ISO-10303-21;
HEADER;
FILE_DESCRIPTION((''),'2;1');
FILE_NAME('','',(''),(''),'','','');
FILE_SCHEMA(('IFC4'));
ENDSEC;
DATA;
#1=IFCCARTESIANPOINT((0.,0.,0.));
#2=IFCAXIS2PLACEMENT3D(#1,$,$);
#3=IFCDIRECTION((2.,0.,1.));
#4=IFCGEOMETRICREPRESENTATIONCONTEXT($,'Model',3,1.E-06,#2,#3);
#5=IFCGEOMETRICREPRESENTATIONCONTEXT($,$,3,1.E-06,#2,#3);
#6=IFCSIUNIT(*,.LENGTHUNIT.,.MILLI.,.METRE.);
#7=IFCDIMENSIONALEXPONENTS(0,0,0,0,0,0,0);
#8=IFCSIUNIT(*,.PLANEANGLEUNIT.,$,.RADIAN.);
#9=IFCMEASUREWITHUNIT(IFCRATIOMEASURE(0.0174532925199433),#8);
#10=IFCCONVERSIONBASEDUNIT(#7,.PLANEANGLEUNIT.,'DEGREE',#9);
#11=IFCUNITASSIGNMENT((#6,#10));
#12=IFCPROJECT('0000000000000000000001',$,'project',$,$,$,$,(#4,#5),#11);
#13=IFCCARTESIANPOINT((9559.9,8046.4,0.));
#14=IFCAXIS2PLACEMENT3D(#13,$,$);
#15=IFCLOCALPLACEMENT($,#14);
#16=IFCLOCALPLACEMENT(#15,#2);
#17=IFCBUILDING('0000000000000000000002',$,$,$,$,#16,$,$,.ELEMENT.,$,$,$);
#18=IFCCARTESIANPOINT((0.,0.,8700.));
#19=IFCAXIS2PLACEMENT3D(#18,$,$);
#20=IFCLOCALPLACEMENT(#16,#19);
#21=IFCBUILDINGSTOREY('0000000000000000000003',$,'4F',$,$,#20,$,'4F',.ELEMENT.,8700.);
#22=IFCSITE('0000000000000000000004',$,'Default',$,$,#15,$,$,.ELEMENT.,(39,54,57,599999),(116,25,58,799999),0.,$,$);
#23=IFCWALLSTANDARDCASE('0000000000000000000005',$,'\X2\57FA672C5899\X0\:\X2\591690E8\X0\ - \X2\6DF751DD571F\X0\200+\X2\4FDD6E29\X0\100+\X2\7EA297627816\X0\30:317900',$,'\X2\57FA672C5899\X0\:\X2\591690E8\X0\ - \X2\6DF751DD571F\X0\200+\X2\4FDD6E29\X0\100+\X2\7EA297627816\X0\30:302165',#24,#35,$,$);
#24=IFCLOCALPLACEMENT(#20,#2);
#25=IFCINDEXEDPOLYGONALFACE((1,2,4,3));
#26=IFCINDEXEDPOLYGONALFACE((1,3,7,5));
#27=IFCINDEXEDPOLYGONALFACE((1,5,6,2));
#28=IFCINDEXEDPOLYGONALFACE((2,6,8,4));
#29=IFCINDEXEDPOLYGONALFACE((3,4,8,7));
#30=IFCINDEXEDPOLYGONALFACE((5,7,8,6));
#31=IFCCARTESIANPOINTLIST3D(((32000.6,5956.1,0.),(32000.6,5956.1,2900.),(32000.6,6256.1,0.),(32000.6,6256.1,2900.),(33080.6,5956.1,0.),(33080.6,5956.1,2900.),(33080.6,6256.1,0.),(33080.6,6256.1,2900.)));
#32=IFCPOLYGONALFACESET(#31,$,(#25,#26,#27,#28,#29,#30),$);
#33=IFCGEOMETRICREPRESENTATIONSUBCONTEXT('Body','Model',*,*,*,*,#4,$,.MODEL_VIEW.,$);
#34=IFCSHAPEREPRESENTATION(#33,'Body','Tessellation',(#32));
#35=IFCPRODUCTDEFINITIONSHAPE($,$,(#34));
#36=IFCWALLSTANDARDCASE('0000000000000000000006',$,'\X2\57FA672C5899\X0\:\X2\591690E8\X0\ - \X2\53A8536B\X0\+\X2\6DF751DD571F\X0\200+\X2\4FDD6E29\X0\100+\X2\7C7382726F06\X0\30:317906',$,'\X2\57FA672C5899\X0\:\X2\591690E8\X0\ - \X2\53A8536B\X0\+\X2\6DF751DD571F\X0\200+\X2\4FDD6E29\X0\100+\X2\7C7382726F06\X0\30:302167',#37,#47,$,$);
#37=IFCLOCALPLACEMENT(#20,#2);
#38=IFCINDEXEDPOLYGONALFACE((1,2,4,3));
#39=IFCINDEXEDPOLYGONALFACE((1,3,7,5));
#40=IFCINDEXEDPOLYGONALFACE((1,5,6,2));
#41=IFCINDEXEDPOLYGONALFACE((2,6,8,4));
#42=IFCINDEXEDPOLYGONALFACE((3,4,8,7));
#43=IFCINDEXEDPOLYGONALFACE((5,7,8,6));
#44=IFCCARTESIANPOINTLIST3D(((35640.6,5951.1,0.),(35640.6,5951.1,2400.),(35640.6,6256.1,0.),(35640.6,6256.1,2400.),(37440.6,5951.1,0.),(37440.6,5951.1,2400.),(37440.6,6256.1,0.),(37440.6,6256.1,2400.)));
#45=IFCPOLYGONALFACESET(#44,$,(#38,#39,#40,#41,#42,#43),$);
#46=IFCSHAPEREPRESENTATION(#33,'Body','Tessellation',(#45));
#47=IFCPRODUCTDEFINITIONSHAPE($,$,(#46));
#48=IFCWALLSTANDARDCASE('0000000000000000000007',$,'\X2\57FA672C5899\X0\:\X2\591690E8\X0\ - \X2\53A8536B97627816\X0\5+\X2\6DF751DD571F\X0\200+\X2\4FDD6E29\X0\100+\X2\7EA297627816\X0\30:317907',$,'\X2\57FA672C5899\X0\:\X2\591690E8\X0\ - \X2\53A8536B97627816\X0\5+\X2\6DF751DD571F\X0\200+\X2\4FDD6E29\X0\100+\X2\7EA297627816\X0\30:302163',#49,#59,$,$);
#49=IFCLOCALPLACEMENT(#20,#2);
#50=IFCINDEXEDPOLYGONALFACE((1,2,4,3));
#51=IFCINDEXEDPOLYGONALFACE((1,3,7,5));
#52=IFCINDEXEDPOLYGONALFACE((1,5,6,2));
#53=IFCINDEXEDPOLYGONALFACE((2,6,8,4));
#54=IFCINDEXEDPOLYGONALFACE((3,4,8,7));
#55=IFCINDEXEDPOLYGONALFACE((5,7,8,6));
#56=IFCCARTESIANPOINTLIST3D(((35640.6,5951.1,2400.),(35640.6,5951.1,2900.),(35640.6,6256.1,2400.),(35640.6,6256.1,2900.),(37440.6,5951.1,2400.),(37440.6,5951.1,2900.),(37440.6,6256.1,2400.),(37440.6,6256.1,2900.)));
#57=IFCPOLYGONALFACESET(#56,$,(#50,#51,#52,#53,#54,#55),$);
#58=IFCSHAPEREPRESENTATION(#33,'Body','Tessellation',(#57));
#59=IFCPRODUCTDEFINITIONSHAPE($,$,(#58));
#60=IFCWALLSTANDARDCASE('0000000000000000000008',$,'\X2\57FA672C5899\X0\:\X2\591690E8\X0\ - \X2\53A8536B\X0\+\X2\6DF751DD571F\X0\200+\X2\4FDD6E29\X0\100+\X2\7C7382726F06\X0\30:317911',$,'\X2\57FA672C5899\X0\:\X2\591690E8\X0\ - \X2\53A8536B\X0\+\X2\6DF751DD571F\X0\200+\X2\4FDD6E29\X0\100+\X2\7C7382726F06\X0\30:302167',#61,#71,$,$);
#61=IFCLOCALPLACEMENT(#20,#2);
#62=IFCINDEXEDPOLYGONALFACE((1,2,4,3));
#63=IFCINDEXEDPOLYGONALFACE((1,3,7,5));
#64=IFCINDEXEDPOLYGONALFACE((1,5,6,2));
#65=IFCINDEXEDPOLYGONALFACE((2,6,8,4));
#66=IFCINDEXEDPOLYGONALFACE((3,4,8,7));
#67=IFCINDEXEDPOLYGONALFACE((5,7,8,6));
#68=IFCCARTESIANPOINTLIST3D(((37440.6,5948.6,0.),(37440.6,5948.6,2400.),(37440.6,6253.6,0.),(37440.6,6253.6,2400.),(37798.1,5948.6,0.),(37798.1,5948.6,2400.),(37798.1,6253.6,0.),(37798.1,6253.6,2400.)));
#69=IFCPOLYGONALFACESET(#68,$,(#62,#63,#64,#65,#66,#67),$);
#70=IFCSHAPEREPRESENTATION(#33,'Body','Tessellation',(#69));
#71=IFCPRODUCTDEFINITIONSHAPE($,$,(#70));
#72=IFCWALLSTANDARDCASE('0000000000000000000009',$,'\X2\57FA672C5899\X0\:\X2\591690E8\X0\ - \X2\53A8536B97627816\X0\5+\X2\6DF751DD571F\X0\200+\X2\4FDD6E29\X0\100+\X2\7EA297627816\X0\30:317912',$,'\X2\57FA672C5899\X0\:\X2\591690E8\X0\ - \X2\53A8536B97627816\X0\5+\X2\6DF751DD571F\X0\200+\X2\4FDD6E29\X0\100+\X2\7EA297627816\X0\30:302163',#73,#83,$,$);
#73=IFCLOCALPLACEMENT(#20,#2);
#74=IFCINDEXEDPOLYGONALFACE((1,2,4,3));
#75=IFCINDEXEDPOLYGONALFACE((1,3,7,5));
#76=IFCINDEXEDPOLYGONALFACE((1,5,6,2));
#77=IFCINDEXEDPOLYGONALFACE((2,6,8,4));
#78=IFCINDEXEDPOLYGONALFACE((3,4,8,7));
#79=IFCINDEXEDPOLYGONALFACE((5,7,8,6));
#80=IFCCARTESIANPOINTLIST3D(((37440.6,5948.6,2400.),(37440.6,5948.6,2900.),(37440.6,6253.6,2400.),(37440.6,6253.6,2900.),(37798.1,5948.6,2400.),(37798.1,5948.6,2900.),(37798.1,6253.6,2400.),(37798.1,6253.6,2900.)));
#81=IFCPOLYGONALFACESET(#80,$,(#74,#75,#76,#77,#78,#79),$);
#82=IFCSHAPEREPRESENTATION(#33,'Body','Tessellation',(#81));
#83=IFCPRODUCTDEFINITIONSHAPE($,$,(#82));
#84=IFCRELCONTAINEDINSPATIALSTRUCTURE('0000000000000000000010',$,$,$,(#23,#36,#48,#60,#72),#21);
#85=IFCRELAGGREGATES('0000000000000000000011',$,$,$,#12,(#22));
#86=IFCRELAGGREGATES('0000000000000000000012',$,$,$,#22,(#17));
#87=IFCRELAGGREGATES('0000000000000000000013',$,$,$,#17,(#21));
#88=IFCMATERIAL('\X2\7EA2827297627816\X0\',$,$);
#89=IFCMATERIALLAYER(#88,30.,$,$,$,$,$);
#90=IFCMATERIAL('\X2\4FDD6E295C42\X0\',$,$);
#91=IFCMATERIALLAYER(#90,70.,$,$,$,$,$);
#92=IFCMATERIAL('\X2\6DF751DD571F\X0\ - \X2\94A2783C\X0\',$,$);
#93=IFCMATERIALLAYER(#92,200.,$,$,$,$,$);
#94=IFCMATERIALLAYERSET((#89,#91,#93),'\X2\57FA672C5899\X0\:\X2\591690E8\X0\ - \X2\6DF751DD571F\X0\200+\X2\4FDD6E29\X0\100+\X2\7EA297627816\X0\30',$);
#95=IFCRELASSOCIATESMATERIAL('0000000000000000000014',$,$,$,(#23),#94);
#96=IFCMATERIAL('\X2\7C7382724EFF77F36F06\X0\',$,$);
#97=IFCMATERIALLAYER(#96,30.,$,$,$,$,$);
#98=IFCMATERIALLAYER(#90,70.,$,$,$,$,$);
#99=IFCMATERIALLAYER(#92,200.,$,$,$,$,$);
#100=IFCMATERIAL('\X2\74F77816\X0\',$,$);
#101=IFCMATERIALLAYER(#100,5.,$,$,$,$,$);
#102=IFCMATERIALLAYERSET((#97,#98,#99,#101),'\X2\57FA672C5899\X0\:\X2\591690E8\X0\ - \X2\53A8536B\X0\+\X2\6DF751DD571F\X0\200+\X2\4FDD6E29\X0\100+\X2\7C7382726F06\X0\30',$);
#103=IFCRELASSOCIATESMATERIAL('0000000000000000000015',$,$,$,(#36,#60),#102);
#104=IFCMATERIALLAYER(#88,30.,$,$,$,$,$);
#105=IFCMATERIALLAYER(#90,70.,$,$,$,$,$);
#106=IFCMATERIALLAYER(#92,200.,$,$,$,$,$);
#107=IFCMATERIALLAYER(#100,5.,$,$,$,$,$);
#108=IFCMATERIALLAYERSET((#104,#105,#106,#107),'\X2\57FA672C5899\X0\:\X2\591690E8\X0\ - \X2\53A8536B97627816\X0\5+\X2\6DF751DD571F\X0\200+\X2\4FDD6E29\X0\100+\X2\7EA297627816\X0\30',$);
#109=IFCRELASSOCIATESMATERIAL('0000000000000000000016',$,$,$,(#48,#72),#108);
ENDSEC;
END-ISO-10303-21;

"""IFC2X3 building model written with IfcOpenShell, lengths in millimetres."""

from ifc_helpers import new_model, entity, si_unit, converted_unit, direction, frame, frame_2d, origin, place, context, subcontext, project, spatial, rectangle, extrude, material, layer, layer_set, layer_usage, element, save


model = new_model("IFC2X3")

# Units and contexts
model_context = context("Model", 3, precision=1e-06, world=origin(), true_north=direction((2.0, 0.0, 1.0)))
context_of_model = context(None, 3, precision=1e-06, world=origin(), true_north=direction((2.0, 0.0, 1.0)))
body_context = subcontext(model_context, "Body", "Model", "MODEL_VIEW")
ifc_project = project(units=[si_unit("LENGTHUNIT", "METRE", prefix="MILLI"), converted_unit("PLANEANGLEUNIT", "DEGREE", entity("IfcRatioMeasure", 0.0174532925199433), si_unit("PLANEANGLEUNIT", "RADIAN"), dimensions=[0, 0, 0, 0, 0, 0, 0])], contexts=[model_context, context_of_model])

# Site, building, storey
site_placement = place(None, frame((9559.9, 8046.4, 0.0)))
site = spatial("IfcSite", under=ifc_project, at=site_placement, Name="Default", CompositionType="ELEMENT", RefLatitude=(39, 54, 57, 599999), RefLongitude=(116, 25, 58, 799999), RefElevation=0.0)
building_placement = place(site_placement, origin())
building = spatial("IfcBuilding", under=site, at=building_placement, CompositionType="ELEMENT")
storey_placement = place(building_placement, frame((0.0, 0.0, 8700.0)))
storey = spatial("IfcBuildingStorey", under=building, at=storey_placement, Name="4F", LongName="4F", CompositionType="ELEMENT", Elevation=8700.0)

# Shared definitions
ifc_material_1 = material(Name="混凝土 - 钢砼")
ifc_material_2 = material(Name="瓷砖")

# Shared definitions
ifc_material_3 = material(Name="红色面砖")
ifc_layer_1 = layer(ifc_material_3, 30.0)
ifc_material_4 = material(Name="保温层")
ifc_layer_2 = layer(ifc_material_4, 70.0)
ifc_layer_3 = layer(ifc_material_1, 200.0)
ifc_layer_set_1 = layer_set([ifc_layer_1, ifc_layer_2, ifc_layer_3], Name="基本墙:外部 - 混凝土200+保温100+红面砖30")

# Shared definitions
ifc_layer_4 = layer(ifc_material_3, 30.0)
ifc_layer_5 = layer(ifc_material_4, 70.0)
ifc_layer_6 = layer(ifc_material_1, 200.0)
ifc_layer_7 = layer(ifc_material_2, 5.0)
ifc_layer_set_2 = layer_set([ifc_layer_4, ifc_layer_5, ifc_layer_6, ifc_layer_7], Name="基本墙:外部 - 厨卫面砖5+混凝土200+保温100+红面砖30")

# Walls
ifc_layer_usage_1 = layer_usage(ifc_layer_set_1, "AXIS2", "POSITIVE", -150.0)
wall_1_placement = place(storey_placement, frame((33080.6, 6106.1, 0.0), z_axis=(0.0, 0.0, 1.0), x_axis=(-1.0, 0.0, 0.0)))
element("IfcWallStandardCase", 1, at=wall_1_placement, inside=storey, material=ifc_layer_usage_1, Name="基本墙:外部 - 混凝土200+保温100+红面砖30:317900", ObjectType="基本墙:外部 - 混凝土200+保温100+红面砖30:302165", context=body_context, shape_type="SweptSolid", body=[
    extrude(rectangle(XDim=1080.0, YDim=300.0, at=frame_2d((540.0, 0.0), x_axis=(-1.0, 0.0))), origin(), (0.0, 0.0, 1.0), 2900.0),
])
ifc_material_5 = material(Name="米色仿石漆")
ifc_layer_8 = layer(ifc_material_5, 30.0)
ifc_layer_9 = layer(ifc_material_4, 70.0)
ifc_layer_10 = layer(ifc_material_1, 200.0)
ifc_layer_11 = layer(ifc_material_2, 5.0)
ifc_layer_set_3 = layer_set([ifc_layer_8, ifc_layer_9, ifc_layer_10, ifc_layer_11], Name="基本墙:外部 - 厨卫+混凝土200+保温100+米色漆30")
ifc_layer_usage_2 = layer_usage(ifc_layer_set_3, "AXIS2", "POSITIVE", -152.5)
wall_2_placement = place(storey_placement, frame((37440.6, 6103.6, 0.0), z_axis=(0.0, 0.0, 1.0), x_axis=(-1.0, 0.0, 0.0)))
element("IfcWallStandardCase", 2, at=wall_2_placement, inside=storey, material=ifc_layer_usage_2, Name="基本墙:外部 - 厨卫+混凝土200+保温100+米色漆30:317906", ObjectType="基本墙:外部 - 厨卫+混凝土200+保温100+米色漆30:302167", context=body_context, shape_type="SweptSolid", body=[
    extrude(rectangle(XDim=1800.0, YDim=305.0, at=frame_2d((900.0, 0.0), x_axis=(-1.0, 0.0))), origin(), (0.0, 0.0, 1.0), 2400.0),
])
ifc_layer_usage_3 = layer_usage(ifc_layer_set_2, "AXIS2", "POSITIVE", -152.5)
wall_3_placement = place(storey_placement, frame((37440.6, 6103.6, 2400.0), z_axis=(0.0, 0.0, 1.0), x_axis=(-1.0, 0.0, 0.0)))
element("IfcWallStandardCase", 3, at=wall_3_placement, inside=storey, material=ifc_layer_usage_3, Name="基本墙:外部 - 厨卫面砖5+混凝土200+保温100+红面砖30:317907", ObjectType="基本墙:外部 - 厨卫面砖5+混凝土200+保温100+红面砖30:302163", context=body_context, shape_type="SweptSolid", body=[
    extrude(rectangle(XDim=1800.0, YDim=305.0, at=frame_2d((900.0, 0.0), x_axis=(-1.0, 0.0))), origin(), (0.0, 0.0, 1.0), 500.0),
])
ifc_layer_usage_4 = layer_usage(ifc_layer_set_3, "AXIS2", "POSITIVE", -152.5)
wall_4_placement = place(storey_placement, frame((37798.1, 6101.1, 0.0), z_axis=(0.0, 0.0, 1.0), x_axis=(-1.0, 0.0, 0.0)))
element("IfcWallStandardCase", 4, at=wall_4_placement, inside=storey, material=ifc_layer_usage_4, Name="基本墙:外部 - 厨卫+混凝土200+保温100+米色漆30:317911", ObjectType="基本墙:外部 - 厨卫+混凝土200+保温100+米色漆30:302167", context=body_context, shape_type="SweptSolid", body=[
    extrude(rectangle(XDim=357.5, YDim=305.0, at=frame_2d((178.7, 0.0), x_axis=(-1.0, 0.0))), origin(), (0.0, 0.0, 1.0), 2400.0),
])
ifc_layer_usage_5 = layer_usage(ifc_layer_set_2, "AXIS2", "POSITIVE", -152.5)
wall_5_placement = place(storey_placement, frame((37798.1, 6101.1, 2400.0), z_axis=(0.0, 0.0, 1.0), x_axis=(-1.0, 0.0, 0.0)))
element("IfcWallStandardCase", 5, at=wall_5_placement, inside=storey, material=ifc_layer_usage_5, Name="基本墙:外部 - 厨卫面砖5+混凝土200+保温100+红面砖30:317912", ObjectType="基本墙:外部 - 厨卫面砖5+混凝土200+保温100+红面砖30:302163", context=body_context, shape_type="SweptSolid", body=[
    extrude(rectangle(XDim=357.5, YDim=305.0, at=frame_2d((178.7, 0.0), x_axis=(-1.0, 0.0))), origin(), (0.0, 0.0, 1.0), 500.0),
])

save(model, "model.ifc")
